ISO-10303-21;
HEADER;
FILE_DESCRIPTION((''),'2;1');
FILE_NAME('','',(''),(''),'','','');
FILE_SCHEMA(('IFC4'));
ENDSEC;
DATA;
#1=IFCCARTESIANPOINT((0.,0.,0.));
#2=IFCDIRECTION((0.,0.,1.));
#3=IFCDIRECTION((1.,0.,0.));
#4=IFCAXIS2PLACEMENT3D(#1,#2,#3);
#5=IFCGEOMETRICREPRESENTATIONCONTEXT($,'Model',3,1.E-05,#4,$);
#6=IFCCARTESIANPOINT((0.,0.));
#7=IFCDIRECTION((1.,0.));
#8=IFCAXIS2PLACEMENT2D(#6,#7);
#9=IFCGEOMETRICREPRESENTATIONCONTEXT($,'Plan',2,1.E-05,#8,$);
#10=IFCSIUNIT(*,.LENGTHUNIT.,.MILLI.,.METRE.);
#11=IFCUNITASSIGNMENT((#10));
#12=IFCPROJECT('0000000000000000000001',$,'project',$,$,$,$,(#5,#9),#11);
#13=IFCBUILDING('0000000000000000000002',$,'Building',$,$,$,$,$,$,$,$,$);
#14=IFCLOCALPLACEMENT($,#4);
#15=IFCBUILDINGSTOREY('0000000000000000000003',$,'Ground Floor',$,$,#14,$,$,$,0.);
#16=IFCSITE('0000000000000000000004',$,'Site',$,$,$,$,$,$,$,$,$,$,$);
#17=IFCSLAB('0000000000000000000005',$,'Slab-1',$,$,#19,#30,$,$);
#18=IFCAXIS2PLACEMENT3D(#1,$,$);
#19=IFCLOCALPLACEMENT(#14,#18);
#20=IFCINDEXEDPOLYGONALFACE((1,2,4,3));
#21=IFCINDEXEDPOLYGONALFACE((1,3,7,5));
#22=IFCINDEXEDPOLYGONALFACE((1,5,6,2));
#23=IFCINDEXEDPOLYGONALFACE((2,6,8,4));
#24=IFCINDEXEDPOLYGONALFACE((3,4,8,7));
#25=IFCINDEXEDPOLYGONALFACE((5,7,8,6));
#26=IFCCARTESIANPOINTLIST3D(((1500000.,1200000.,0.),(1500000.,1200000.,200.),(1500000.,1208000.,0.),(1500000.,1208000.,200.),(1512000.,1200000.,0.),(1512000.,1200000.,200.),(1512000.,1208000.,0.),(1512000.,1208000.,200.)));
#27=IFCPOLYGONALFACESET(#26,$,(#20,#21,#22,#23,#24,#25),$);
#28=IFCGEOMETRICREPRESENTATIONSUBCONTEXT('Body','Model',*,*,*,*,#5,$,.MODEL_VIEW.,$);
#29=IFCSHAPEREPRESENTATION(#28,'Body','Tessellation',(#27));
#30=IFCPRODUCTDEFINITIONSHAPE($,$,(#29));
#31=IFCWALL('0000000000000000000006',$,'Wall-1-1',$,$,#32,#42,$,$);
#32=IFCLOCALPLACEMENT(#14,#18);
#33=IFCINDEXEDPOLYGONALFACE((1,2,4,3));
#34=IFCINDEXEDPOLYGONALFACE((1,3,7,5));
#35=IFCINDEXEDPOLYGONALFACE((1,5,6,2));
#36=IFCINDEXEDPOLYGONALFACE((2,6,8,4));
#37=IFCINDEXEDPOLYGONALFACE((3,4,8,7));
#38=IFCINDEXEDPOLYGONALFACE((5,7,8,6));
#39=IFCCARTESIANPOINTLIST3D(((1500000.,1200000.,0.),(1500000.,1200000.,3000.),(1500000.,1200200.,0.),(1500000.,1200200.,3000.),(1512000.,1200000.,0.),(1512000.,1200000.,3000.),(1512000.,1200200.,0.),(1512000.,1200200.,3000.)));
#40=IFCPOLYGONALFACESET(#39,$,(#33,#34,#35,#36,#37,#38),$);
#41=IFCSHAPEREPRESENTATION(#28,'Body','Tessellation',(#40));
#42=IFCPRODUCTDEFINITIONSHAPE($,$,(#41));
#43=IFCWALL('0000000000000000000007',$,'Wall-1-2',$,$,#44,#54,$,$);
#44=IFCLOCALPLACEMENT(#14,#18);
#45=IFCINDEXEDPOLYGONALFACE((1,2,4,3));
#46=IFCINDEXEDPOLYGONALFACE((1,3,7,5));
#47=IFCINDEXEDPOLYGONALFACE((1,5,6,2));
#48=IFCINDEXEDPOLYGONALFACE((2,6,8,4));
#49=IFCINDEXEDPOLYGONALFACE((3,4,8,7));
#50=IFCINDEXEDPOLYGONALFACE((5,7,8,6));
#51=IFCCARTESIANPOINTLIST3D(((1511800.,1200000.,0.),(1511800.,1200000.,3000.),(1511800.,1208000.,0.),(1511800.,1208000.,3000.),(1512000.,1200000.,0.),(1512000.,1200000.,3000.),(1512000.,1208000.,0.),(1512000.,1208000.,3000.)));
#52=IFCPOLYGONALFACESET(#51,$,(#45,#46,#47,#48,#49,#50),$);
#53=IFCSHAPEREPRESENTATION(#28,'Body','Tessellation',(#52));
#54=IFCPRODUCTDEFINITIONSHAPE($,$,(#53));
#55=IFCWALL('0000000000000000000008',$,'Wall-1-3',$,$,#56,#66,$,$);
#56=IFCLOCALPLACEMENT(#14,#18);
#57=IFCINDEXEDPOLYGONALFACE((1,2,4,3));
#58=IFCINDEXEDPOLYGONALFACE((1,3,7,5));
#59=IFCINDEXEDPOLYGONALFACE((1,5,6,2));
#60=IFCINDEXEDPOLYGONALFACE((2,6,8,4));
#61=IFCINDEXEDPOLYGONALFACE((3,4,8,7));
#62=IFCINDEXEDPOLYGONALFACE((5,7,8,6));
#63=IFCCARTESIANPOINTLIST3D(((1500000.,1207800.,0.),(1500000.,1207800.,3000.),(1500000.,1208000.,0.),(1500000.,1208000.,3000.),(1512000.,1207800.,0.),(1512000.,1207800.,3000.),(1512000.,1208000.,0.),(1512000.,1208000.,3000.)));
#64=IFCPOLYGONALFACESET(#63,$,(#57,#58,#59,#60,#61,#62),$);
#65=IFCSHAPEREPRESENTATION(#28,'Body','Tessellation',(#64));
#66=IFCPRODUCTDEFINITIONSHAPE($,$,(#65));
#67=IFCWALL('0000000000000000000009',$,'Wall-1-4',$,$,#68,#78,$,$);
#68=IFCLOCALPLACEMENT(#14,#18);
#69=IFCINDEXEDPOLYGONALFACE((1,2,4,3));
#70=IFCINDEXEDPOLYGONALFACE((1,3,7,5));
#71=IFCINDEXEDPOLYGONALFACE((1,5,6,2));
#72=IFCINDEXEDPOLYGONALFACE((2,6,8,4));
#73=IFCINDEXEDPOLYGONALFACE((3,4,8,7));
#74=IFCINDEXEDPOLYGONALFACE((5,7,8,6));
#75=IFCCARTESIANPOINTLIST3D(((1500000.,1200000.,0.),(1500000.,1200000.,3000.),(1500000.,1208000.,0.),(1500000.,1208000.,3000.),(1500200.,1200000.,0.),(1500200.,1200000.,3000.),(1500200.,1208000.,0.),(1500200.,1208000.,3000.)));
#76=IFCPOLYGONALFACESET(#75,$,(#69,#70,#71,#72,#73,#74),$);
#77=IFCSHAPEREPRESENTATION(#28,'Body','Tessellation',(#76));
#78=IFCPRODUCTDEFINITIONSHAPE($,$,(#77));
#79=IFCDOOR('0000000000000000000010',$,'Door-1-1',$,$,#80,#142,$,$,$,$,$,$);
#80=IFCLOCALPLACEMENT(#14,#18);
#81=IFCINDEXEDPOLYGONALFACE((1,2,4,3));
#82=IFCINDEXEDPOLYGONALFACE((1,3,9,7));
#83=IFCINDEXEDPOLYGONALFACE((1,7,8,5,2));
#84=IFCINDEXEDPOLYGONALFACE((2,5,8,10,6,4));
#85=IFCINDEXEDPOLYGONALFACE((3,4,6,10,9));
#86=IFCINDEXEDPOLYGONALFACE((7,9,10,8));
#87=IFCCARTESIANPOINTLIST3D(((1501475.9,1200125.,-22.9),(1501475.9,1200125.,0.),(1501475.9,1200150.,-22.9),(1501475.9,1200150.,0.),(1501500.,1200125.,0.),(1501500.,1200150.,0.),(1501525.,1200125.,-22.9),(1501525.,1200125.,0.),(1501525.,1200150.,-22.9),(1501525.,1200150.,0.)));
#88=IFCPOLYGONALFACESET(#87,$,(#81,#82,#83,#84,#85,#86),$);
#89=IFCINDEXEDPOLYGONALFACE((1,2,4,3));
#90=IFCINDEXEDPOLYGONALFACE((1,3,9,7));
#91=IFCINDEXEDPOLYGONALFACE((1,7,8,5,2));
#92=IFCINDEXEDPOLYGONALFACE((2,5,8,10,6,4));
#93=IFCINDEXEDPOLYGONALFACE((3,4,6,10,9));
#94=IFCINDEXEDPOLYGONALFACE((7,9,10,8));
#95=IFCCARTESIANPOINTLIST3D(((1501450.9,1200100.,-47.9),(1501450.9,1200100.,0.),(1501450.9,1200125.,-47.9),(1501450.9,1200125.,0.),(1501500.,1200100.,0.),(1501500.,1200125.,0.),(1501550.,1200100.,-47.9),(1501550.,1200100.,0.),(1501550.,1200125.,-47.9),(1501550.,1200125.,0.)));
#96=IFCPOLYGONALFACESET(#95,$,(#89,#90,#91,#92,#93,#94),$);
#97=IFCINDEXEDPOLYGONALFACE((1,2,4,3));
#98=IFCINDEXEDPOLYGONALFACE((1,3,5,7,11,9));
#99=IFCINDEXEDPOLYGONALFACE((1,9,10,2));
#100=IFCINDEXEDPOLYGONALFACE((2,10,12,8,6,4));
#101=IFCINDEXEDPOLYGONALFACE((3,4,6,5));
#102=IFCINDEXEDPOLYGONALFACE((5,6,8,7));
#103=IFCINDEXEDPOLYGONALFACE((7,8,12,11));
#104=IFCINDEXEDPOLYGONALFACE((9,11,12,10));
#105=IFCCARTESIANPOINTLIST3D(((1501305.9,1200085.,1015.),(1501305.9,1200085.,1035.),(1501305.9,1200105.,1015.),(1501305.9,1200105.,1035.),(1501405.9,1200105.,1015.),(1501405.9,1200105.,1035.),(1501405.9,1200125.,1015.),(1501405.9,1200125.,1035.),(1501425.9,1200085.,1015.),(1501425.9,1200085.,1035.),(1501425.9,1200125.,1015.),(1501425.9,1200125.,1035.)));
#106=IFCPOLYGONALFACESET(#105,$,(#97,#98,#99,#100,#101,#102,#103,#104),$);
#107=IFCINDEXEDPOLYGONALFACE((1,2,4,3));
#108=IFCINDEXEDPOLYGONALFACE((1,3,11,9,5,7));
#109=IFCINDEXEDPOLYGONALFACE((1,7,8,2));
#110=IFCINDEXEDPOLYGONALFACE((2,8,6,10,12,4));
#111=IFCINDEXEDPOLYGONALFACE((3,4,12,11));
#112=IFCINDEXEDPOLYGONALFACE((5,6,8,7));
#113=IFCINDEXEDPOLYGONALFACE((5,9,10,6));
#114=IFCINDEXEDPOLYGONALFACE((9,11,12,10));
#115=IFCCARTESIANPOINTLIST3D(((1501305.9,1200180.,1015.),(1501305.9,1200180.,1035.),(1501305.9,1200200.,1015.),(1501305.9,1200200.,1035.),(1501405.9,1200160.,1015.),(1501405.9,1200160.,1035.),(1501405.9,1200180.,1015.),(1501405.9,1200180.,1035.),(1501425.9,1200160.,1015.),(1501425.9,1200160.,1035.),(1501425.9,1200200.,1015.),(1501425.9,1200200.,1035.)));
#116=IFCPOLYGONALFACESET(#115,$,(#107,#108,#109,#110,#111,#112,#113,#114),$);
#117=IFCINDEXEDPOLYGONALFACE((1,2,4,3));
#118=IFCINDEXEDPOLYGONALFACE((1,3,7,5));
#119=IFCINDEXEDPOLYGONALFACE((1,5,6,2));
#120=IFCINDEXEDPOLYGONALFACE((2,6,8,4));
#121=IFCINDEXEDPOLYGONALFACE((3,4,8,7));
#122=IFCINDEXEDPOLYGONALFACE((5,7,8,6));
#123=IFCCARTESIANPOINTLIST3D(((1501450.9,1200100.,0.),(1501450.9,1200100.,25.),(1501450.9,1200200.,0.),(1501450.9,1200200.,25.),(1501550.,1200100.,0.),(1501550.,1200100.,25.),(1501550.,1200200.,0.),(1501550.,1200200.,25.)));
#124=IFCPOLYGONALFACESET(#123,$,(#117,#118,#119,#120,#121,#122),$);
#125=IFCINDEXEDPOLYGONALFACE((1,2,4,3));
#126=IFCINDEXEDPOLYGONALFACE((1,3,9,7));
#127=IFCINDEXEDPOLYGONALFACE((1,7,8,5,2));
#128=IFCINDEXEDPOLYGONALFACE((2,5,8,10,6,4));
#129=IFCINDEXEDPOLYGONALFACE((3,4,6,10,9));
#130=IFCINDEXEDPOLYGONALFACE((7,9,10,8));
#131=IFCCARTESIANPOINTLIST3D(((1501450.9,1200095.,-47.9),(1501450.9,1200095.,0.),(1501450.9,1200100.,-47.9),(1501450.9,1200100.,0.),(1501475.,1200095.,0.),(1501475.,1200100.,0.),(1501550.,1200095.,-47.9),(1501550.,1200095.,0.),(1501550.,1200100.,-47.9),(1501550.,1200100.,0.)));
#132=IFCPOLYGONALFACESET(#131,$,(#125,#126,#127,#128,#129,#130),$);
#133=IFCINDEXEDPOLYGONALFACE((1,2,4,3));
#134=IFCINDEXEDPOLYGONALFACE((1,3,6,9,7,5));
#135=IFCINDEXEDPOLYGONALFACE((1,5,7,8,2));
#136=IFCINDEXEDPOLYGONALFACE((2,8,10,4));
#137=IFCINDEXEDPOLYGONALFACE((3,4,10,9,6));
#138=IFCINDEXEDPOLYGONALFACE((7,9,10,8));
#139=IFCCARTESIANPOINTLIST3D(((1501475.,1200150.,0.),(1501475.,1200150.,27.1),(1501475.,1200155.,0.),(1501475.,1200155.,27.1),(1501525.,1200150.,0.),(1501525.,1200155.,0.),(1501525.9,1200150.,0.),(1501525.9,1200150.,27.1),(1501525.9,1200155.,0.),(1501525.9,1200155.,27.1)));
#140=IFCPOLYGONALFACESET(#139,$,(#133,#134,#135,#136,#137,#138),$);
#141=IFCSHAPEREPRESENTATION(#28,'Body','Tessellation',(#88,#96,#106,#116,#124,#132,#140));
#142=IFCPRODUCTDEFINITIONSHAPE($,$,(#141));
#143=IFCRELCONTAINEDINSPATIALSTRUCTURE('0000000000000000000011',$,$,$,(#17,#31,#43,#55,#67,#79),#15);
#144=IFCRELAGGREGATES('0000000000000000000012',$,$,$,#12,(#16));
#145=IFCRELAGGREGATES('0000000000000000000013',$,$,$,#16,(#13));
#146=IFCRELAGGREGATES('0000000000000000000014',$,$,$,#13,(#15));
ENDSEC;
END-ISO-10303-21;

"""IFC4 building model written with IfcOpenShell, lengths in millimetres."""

from ifc_helpers import new_model, si_unit, frame, origin_with_axes, origin_2d_with_axis, place, context, subcontext, project, spatial, line, indexed_curve, outline, extrude, element, save


model = new_model("IFC4")

# Units and contexts
model_context = context("Model", 3, precision=1e-05, world=origin_with_axes())
plan_context = context("Plan", 2, precision=1e-05, world=origin_2d_with_axis())
body_context = subcontext(model_context, "Body", "Model", "MODEL_VIEW")
ifc_project = project(units=[si_unit("LENGTHUNIT", "METRE", prefix="MILLI")], contexts=[model_context, plan_context])

# Site, building, storey
site = spatial("IfcSite", under=ifc_project, Name="Site")
building = spatial("IfcBuilding", under=site, Name="Building")
storey_placement = place(None, origin_with_axes())
storey = spatial("IfcBuildingStorey", under=building, at=storey_placement, Name="Ground Floor", Elevation=0.0)

# Slab
slab_placement = place(storey_placement, frame((1500000.0, 1200000.0, 0.0), z_axis=(0.0, 0.0, 1.0), x_axis=(1.0, 0.0, 0.0)))
element("IfcSlab", 1, at=slab_placement, inside=storey, Name="Slab-1", context=body_context, shape_type="SweptSolid", body=[
    extrude(outline(indexed_curve([(0.0, 0.0), (12000.0, 0.0), (12000.0, 8000.0), (0.0, 8000.0), (0.0, 0.0)])), None, (0.0, 0.0, 1.0), 200.0),
])

# Walls
wall_1_placement = place(storey_placement, frame((1500000.0, 1200000.0, 0.0), z_axis=(0.0, 0.0, 1.0), x_axis=(1.0, 0.0, 0.0)))
element("IfcWall", 2, at=wall_1_placement, inside=storey, Name="Wall-1-1", context=body_context, shape_type="SweptSolid", body=[
    extrude(outline(indexed_curve([(0.0, 0.0), (0.0, 200.0), (12000.0, 200.0), (12000.0, 0.0), (0.0, 0.0)], self_intersect=False)), origin_with_axes(), (0.0, 0.0, 1.0), 3000.0),
])
wall_2_placement = place(storey_placement, frame((1512000.0, 1200000.0, 0.0), z_axis=(0.0, 0.0, 1.0), x_axis=(0.0, 1.0, 0.0)))
element("IfcWall", 3, at=wall_2_placement, inside=storey, Name="Wall-1-2", context=body_context, shape_type="SweptSolid", body=[
    extrude(outline(indexed_curve([(0.0, 0.0), (0.0, 200.0), (8000.0, 200.0), (8000.0, 0.0), (0.0, 0.0)], self_intersect=False)), origin_with_axes(), (0.0, 0.0, 1.0), 3000.0),
])
wall_3_placement = place(storey_placement, frame((1512000.0, 1208000.0, 0.0), z_axis=(0.0, 0.0, 1.0), x_axis=(-1.0, 0.0, 0.0)))
element("IfcWall", 4, at=wall_3_placement, inside=storey, Name="Wall-1-3", context=body_context, shape_type="SweptSolid", body=[
    extrude(outline(indexed_curve([(0.0, 0.0), (0.0, 200.0), (12000.0, 200.0), (12000.0, 0.0), (0.0, 0.0)], self_intersect=False)), origin_with_axes(), (0.0, 0.0, 1.0), 3000.0),
])
wall_4_placement = place(storey_placement, frame((1500000.0, 1208000.0, 0.0), z_axis=(0.0, 0.0, 1.0), x_axis=(0.0, -1.0, 0.0)))
element("IfcWall", 5, at=wall_4_placement, inside=storey, Name="Wall-1-4", context=body_context, shape_type="SweptSolid", body=[
    extrude(outline(indexed_curve([(0.0, 0.0), (0.0, 200.0), (8000.0, 200.0), (8000.0, 0.0), (0.0, 0.0)], self_intersect=False)), origin_with_axes(), (0.0, 0.0, 1.0), 3000.0),
])

# Door
door_1_placement = place(storey_placement, frame((1501500.0, 1200100.0, 0.0), z_axis=(0.0, 0.0, 1.0), x_axis=(1.0, 0.0, 0.0)))
element("IfcDoor", 6, at=door_1_placement, inside=storey, Name="Door-1-1", context=body_context, shape_type="SweptSolid", body=[
    extrude(outline(indexed_curve([(0.0, 0.0), (0.0, 2.1), (0.9, 2.1), (0.9, 0.0), (-24.1, 0.0), (-24.1, -22.9), (25.0, -22.9), (25.0, 0.0)], segments=[line(1, 2, 3, 4, 5, 6, 7, 8, 1)])), frame((0.0, 25.0, 0.0), z_axis=(0.0, -1.0, 0.0), x_axis=(1.0, 0.0, 0.0)), (0.0, 0.0, -1.0), 25.0),
    extrude(outline(indexed_curve([(0.0, 0.0), (0.0, 2.1), (0.9, 2.1), (0.9, 0.0), (-49.1, 0.0), (-49.1, -47.9), (50.0, -47.9), (50.0, 0.0)], segments=[line(1, 2, 3, 4, 5, 6, 7, 8, 1)])), frame((0.0, 0.0, 0.0), z_axis=(0.0, -1.0, 0.0), x_axis=(1.0, 0.0, 0.0)), (0.0, 0.0, -1.0), 25.0),
    extrude(outline(indexed_curve([(0.0, 0.0), (-49.1, 0.0), (-49.1, 35.0), (0.0, 35.0)], segments=[line(1, 2, 3, 4, 1)])), frame((25.0, 25.0, 25.0), z_axis=(0.0, 0.0, 1.0), x_axis=(1.0, 0.0, 0.0)), (0.0, 0.0, 1.0), -47.9),
    extrude(outline(indexed_curve([(0.0, 0.0), (0.0, -40.0), (-120.0, -40.0), (-120.0, -20.0), (-20.0, -20.0), (-20.0, 0.0)], segments=[line(1, 2, 3, 4, 5, 6, 1)])), frame((-74.1, 25.0, 1015.0), z_axis=(0.0, 0.0, 1.0), x_axis=(1.0, 0.0, 0.0)), (0.0, 0.0, 1.0), 20.0),
    extrude(outline(indexed_curve([(0.0, 0.0), (0.0, 40.0), (-120.0, 40.0), (-120.0, 20.0), (-20.0, 20.0), (-20.0, 0.0)], segments=[line(1, 2, 3, 4, 5, 6, 1)])), frame((-74.1, 60.0, 1015.0), z_axis=(0.0, 0.0, 1.0), x_axis=(1.0, 0.0, 0.0)), (0.0, 0.0, 1.0), 20.0),
    extrude(outline(indexed_curve([(0.0, 0.0), (-99.1, 0.0), (-99.1, 100.0), (0.0, 100.0)], segments=[line(1, 2, 3, 4, 1)])), frame((50.0, 0.0, 0.0), z_axis=(0.0, 0.0, 1.0), x_axis=(1.0, 0.0, 0.0)), (0.0, 0.0, 1.0), 25.0),
    extrude(outline(indexed_curve([(0.0, 0.0), (0.0, 27.1), (50.9, 27.1), (50.9, 0.0), (-24.1, 0.0), (-24.1, -47.9), (75.0, -47.9), (75.0, 0.0)], segments=[line(1, 2, 3, 4, 5, 6, 7, 8, 1)])), frame((-25.0, -5.0, 0.0), z_axis=(0.0, -1.0, 0.0), x_axis=(1.0, 0.0, 0.0)), (0.0, 0.0, -1.0), 5.0),
    extrude(outline(indexed_curve([(0.0, 0.0), (0.0, 27.1), (50.9, 27.1), (50.9, 0.0), (0.9, 0.0), (0.9, -22.9), (50.0, -22.9), (50.0, 0.0)], segments=[line(1, 2, 3, 4, 5, 6, 7, 8, 1)])), frame((-25.0, 50.0, 0.0), z_axis=(0.0, -1.0, 0.0), x_axis=(1.0, 0.0, 0.0)), (0.0, 0.0, -1.0), 5.0),
])

save(model, "model.ifc")
